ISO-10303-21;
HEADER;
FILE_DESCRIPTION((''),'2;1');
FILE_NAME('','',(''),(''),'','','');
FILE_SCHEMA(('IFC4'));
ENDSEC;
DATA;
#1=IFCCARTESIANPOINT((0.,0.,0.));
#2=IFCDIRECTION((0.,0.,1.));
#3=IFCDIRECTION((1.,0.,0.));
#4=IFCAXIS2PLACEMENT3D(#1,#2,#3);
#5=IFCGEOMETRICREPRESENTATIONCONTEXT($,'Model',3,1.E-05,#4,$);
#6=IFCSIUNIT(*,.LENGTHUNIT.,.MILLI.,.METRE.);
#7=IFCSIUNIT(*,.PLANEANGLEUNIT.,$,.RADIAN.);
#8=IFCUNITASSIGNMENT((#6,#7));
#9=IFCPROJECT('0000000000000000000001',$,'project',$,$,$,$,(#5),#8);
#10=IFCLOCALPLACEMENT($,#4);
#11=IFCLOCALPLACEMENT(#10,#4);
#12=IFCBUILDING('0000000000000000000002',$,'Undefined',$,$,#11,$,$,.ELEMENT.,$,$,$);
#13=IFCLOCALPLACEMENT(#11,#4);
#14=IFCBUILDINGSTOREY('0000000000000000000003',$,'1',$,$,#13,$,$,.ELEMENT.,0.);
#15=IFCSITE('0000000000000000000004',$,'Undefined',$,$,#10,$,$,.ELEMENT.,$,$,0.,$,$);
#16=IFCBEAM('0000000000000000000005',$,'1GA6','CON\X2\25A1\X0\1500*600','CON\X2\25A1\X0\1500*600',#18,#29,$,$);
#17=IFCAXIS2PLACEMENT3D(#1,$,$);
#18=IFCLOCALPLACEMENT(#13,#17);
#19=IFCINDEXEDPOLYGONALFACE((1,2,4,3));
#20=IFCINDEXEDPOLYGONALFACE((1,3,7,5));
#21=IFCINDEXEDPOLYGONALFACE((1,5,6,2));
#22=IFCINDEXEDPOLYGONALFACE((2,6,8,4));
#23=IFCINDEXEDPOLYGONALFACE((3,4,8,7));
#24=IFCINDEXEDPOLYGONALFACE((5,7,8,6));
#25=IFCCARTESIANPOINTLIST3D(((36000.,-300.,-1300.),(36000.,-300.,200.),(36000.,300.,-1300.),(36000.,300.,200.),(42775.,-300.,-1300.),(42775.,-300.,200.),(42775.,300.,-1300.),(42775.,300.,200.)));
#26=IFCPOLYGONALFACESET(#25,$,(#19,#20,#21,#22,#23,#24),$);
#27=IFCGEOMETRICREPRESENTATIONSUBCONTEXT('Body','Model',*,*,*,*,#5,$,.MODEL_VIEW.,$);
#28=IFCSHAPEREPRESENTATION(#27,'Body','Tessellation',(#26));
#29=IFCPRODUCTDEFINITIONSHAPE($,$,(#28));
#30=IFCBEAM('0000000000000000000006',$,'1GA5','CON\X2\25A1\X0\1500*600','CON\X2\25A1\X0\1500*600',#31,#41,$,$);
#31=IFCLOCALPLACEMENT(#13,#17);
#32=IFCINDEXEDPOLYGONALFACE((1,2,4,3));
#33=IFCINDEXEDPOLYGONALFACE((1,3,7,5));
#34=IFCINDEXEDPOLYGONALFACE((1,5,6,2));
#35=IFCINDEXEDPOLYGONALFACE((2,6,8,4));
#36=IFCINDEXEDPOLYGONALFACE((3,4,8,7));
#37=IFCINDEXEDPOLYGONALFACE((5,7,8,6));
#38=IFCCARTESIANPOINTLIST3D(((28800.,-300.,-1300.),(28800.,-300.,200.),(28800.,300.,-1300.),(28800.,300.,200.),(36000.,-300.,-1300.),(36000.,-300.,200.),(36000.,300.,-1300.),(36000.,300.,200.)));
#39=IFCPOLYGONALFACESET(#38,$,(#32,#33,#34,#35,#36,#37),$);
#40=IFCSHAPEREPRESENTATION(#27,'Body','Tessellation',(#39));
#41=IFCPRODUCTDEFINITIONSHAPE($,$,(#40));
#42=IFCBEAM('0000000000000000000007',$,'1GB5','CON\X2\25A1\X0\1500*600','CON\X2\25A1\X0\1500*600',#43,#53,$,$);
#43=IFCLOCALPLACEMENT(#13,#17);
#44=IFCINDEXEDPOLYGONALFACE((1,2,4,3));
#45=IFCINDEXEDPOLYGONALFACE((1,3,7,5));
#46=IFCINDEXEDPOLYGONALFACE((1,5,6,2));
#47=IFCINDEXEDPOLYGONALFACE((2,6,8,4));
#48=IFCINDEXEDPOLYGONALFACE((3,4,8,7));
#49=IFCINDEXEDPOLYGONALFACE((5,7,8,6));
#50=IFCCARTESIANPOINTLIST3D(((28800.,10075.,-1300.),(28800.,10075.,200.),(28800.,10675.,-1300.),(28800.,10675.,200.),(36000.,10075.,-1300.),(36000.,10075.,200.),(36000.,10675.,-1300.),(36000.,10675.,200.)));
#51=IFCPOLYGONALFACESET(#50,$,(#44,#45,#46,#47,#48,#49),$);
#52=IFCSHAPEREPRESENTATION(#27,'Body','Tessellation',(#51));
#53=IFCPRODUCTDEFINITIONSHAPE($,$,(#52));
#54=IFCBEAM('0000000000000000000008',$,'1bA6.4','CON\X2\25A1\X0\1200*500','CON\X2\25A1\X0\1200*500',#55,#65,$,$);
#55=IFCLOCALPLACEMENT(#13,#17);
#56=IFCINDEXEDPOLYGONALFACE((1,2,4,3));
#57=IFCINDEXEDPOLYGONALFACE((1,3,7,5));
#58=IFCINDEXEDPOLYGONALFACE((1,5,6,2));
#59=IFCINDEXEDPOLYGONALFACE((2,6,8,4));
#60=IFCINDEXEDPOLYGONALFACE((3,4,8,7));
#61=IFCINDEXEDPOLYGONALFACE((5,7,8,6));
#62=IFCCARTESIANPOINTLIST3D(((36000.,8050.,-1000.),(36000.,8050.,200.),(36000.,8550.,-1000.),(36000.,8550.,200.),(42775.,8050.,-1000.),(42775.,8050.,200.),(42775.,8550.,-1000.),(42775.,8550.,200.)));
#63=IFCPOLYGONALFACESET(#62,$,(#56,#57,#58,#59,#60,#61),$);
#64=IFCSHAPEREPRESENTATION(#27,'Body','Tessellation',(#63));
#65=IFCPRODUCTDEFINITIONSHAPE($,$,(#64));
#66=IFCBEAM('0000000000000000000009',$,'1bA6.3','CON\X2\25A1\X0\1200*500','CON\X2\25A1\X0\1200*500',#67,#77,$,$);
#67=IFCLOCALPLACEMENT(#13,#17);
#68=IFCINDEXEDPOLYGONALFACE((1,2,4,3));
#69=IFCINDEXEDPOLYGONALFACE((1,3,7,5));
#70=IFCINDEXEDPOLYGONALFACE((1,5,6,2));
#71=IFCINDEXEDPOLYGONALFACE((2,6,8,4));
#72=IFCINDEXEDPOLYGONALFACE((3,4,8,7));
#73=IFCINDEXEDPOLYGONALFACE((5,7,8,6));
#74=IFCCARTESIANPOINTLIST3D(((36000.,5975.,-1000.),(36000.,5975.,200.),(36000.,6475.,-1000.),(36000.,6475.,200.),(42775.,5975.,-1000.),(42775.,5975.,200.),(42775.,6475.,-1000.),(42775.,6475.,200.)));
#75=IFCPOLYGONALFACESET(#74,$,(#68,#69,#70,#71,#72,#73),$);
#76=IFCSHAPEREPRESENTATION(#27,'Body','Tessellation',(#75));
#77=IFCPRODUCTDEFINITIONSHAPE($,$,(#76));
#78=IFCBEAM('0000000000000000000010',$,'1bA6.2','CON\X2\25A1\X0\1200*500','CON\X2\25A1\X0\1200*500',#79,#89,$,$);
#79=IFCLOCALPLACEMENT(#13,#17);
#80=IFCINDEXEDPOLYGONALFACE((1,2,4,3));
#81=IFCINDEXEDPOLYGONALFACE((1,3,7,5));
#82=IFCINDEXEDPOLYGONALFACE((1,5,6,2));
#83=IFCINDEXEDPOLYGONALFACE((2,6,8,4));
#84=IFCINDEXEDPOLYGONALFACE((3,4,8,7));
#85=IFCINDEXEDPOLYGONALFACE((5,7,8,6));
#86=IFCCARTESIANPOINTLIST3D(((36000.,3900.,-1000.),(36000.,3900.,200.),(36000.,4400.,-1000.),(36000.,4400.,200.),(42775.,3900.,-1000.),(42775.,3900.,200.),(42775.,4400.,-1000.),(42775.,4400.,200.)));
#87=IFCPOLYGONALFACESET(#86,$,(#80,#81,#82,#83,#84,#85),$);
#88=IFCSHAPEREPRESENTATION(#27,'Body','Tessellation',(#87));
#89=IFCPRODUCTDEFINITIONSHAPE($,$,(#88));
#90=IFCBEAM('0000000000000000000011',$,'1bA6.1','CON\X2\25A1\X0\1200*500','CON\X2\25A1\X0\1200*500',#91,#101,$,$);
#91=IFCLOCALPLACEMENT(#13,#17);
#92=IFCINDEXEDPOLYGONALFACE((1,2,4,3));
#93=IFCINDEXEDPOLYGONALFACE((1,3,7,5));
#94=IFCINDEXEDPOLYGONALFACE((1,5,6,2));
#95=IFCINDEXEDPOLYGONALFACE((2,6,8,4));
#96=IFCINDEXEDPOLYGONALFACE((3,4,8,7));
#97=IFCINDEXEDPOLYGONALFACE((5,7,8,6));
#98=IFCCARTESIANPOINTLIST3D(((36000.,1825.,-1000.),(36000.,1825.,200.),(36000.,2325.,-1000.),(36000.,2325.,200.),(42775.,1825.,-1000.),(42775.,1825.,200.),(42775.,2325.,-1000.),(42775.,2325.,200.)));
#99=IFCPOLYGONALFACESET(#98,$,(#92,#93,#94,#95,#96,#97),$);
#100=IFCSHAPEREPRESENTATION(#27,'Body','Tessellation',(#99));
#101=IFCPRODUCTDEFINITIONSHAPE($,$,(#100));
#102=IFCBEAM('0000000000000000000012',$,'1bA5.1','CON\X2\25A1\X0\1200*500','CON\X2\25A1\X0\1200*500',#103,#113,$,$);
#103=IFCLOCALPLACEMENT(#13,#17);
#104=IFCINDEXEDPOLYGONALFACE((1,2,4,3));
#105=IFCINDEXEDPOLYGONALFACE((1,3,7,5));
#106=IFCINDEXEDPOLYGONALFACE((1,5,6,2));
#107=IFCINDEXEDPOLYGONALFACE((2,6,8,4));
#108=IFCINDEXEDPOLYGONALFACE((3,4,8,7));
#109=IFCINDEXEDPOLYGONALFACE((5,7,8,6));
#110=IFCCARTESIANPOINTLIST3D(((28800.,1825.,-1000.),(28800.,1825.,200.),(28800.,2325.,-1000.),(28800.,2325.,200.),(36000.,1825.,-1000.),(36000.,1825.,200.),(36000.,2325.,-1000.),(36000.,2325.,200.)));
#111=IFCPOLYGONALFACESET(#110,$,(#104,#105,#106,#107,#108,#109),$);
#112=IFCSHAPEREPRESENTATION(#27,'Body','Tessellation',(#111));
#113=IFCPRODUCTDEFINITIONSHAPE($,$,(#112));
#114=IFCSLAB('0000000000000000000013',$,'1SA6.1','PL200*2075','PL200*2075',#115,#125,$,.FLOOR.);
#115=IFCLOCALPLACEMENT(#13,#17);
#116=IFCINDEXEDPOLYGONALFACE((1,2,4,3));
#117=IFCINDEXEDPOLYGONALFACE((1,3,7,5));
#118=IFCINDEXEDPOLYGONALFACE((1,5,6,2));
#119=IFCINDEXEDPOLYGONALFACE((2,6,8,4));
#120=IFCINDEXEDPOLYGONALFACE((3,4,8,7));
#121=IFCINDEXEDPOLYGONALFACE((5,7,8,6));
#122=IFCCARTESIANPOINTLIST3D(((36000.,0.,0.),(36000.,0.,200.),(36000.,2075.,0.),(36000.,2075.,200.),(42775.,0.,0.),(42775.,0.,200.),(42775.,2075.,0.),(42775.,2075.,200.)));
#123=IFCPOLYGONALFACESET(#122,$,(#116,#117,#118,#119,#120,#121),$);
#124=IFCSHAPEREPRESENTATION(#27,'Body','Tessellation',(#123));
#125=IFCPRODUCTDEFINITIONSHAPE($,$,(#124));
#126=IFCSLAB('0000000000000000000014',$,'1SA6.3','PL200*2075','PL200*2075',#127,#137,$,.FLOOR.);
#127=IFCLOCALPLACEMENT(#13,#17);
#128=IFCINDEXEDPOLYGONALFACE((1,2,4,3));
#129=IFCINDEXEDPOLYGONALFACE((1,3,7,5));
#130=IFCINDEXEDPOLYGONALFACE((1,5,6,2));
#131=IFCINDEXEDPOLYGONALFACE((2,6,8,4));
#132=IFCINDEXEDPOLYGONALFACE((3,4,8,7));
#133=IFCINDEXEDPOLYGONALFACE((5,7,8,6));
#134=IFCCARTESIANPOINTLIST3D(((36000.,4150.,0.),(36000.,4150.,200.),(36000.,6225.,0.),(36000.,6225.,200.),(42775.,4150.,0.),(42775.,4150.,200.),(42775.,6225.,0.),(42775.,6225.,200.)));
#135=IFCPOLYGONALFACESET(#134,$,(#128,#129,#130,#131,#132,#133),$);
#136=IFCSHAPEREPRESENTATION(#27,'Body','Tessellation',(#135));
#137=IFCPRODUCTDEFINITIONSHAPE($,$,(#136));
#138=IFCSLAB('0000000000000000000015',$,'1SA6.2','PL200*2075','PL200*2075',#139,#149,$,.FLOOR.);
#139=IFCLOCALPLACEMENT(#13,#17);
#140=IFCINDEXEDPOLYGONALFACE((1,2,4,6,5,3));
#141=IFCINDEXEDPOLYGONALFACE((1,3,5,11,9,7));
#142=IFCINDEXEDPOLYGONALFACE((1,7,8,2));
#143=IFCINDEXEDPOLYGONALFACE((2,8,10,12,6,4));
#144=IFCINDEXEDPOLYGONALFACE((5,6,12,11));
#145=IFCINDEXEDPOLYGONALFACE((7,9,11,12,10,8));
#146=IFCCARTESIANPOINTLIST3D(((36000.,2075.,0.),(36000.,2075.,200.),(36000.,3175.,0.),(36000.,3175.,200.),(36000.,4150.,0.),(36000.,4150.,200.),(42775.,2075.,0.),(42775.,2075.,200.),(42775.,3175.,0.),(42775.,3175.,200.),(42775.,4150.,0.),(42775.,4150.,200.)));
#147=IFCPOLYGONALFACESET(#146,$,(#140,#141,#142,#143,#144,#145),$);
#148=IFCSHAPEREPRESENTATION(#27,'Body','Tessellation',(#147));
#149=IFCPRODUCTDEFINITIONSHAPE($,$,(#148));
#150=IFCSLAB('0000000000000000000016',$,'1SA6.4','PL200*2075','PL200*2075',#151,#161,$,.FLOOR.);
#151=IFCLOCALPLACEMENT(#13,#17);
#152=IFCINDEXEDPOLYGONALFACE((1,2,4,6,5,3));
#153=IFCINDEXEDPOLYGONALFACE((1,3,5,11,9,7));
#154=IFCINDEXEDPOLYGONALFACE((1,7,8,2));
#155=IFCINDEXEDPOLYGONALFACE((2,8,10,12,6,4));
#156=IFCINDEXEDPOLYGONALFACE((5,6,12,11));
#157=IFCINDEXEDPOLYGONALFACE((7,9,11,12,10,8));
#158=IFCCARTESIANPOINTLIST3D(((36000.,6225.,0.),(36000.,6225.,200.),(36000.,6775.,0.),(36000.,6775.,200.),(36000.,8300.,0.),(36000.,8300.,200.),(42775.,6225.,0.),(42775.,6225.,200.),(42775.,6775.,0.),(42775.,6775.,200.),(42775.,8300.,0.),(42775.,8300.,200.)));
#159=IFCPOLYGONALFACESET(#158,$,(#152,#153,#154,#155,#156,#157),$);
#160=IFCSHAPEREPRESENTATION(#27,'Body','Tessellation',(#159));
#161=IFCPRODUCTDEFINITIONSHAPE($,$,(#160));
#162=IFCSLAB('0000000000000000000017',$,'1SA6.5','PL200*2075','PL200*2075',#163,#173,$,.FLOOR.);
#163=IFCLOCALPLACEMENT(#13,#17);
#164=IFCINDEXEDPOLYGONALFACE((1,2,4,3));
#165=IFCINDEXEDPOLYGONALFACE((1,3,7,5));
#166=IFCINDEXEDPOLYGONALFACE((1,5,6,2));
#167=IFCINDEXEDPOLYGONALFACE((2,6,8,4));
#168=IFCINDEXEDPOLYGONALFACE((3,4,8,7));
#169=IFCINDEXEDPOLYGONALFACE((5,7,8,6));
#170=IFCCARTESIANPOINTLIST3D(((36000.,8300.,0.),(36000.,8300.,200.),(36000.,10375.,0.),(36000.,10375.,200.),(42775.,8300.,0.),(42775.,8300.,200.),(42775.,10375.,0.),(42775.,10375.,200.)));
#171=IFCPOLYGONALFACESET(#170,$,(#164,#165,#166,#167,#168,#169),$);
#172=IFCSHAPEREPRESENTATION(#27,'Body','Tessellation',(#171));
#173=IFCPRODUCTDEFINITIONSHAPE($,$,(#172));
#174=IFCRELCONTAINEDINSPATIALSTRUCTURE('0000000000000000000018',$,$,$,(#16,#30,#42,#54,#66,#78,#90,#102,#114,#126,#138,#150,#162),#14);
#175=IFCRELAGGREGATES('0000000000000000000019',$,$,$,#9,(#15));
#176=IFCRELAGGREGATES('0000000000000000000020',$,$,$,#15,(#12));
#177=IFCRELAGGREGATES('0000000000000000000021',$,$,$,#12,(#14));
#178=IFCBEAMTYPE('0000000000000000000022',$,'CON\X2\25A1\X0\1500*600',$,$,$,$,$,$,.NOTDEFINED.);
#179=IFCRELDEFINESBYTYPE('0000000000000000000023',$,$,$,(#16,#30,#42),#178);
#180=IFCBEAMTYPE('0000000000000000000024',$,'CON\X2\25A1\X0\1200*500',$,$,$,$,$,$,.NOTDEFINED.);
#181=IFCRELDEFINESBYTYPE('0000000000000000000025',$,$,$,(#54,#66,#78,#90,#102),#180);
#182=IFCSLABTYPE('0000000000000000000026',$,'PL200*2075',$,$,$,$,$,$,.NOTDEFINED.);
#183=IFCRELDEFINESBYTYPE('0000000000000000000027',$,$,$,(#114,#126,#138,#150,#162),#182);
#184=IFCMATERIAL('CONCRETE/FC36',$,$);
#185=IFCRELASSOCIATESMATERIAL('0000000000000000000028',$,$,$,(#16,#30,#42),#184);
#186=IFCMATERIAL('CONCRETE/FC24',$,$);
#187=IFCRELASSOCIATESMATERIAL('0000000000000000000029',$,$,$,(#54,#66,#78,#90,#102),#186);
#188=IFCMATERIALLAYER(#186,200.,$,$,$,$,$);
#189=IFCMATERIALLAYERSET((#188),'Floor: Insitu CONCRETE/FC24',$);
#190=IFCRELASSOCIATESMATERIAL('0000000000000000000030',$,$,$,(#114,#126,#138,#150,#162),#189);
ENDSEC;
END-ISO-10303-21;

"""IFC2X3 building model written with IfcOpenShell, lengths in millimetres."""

from ifc_helpers import new_model, si_unit, frame, origin_with_axes, origin_2d_with_axis, place, context, subcontext, project, spatial, polyline, rectangle, outline, extrude, material, layer, layer_set, layer_usage, type_object, element, save


model = new_model("IFC2X3")

# Units and contexts
model_context = context("Model", 3, precision=1e-05, world=origin_with_axes())
body_context = subcontext(model_context, "Body", "Model", "MODEL_VIEW")
ifc_project = project(units=[si_unit("LENGTHUNIT", "METRE", prefix="MILLI"), si_unit("PLANEANGLEUNIT", "RADIAN")], contexts=[model_context])

# Site, building, storey
site_placement = place(None, origin_with_axes())
site = spatial("IfcSite", under=ifc_project, at=site_placement, Name="Undefined", CompositionType="ELEMENT", RefElevation=0.0)
building_placement = place(site_placement, origin_with_axes())
building = spatial("IfcBuilding", under=site, at=building_placement, Name="Undefined", CompositionType="ELEMENT")
storey_placement = place(building_placement, origin_with_axes())
storey = spatial("IfcBuildingStorey", under=building, at=storey_placement, Name="1", CompositionType="ELEMENT", Elevation=0.0)

# Shared definitions
ifc_material_1 = material(Name="CONCRETE/FC24")

# Beams
ifc_material_2 = material(Name="CONCRETE/FC36")
beam_type_1 = type_object("IfcBeamType", Name="CON□1500*600", PredefinedType="NOTDEFINED")
beam_1_placement = place(storey_placement, frame((36000.0, 0.0, -550.0), z_axis=(0.0, 0.0, 1.0), x_axis=(1.0, 0.0, 0.0)))
element("IfcBeam", 1, at=beam_1_placement, inside=storey, type_object=beam_type_1, material=ifc_material_2, Name="1GA6", Description="CON□1500*600", ObjectType="CON□1500*600", context=body_context, shape_type="SweptSolid", body=[
    extrude(rectangle(XDim=600.0, YDim=1500.0, at=origin_2d_with_axis()), frame((6775.0, 0.0, 0.0), z_axis=(-1.0, 0.0, 0.0), x_axis=(0.0, -1.0, 0.0)), (0.0, 0.0, 1.0), 6775.0),
])
for number, where, z_axis, x_axis, name in (
    (2, (28800.0, 0.0, -550.0), (0.0, 0.0, 1.0), (1.0, 0.0, 0.0), "1GA5"),
    (3, (28800.0, 10375.0, -550.0), (0.0, 0.0, 1.0), (1.0, 0.0, 0.0), "1GB5"),
):
    element("IfcBeam", number, at=place(storey_placement, frame(where, z_axis=z_axis, x_axis=x_axis)), inside=storey, type_object=beam_type_1, material=ifc_material_2, Name=name, Description="CON□1500*600", ObjectType="CON□1500*600", context=body_context, shape_type="SweptSolid", body=[
        extrude(rectangle(XDim=600.0, YDim=1500.0, at=origin_2d_with_axis()), frame((7200.0, 0.0, 0.0), z_axis=(-1.0, 0.0, 0.0), x_axis=(0.0, -1.0, 0.0)), (0.0, 0.0, 1.0), 7200.0),
    ])
beam_type_2 = type_object("IfcBeamType", Name="CON□1200*500", PredefinedType="NOTDEFINED")
for number, where, z_axis, x_axis, name in (
    (4, (36000.0, 8300.0, -400.0), (0.0, 0.0, 1.0), (1.0, 0.0, 0.0), "1bA6.4"),
    (5, (36000.0, 6225.0, -400.0), (0.0, 0.0, 1.0), (1.0, 0.0, 0.0), "1bA6.3"),
    (6, (36000.0, 4150.0, -400.0), (0.0, 0.0, 1.0), (1.0, 0.0, 0.0), "1bA6.2"),
    (7, (36000.0, 2075.0, -400.0), (0.0, 0.0, 1.0), (1.0, 0.0, 0.0), "1bA6.1"),
):
    element("IfcBeam", number, at=place(storey_placement, frame(where, z_axis=z_axis, x_axis=x_axis)), inside=storey, type_object=beam_type_2, material=ifc_material_1, Name=name, Description="CON□1200*500", ObjectType="CON□1200*500", context=body_context, shape_type="SweptSolid", body=[
        extrude(rectangle(XDim=500.0, YDim=1200.0, at=origin_2d_with_axis()), frame((6775.0, 0.0, 0.0), z_axis=(-1.0, 0.0, 0.0), x_axis=(0.0, -1.0, 0.0)), (0.0, 0.0, 1.0), 6775.0),
    ])
beam_2_placement = place(storey_placement, frame((28800.0, 2075.0, -400.0), z_axis=(0.0, 0.0, 1.0), x_axis=(1.0, 0.0, 0.0)))
element("IfcBeam", 8, at=beam_2_placement, inside=storey, type_object=beam_type_2, material=ifc_material_1, Name="1bA5.1", Description="CON□1200*500", ObjectType="CON□1200*500", context=body_context, shape_type="SweptSolid", body=[
    extrude(rectangle(XDim=500.0, YDim=1200.0, at=origin_2d_with_axis()), frame((7200.0, 0.0, 0.0), z_axis=(-1.0, 0.0, 0.0), x_axis=(0.0, -1.0, 0.0)), (0.0, 0.0, 1.0), 7200.0),
])

# Slabs
ifc_layer = layer(ifc_material_1, 200.0)
ifc_layer_set = layer_set([ifc_layer], Name="Floor: Insitu CONCRETE/FC24")
ifc_layer_usage_1 = layer_usage(ifc_layer_set, "AXIS3", "POSITIVE", -100.0)
slab_type = type_object("IfcSlabType", Name="PL200*2075", PredefinedType="NOTDEFINED")
slab_1_placement = place(storey_placement, frame((36000.0, 0.0, 100.0), z_axis=(0.0, 0.0, 1.0), x_axis=(1.0, 0.0, 0.0)))
element("IfcSlab", 9, at=slab_1_placement, inside=storey, type_object=slab_type, material=ifc_layer_usage_1, Name="1SA6.1", Description="PL200*2075", ObjectType="PL200*2075", PredefinedType="FLOOR", context=body_context, shape_type="SweptSolid", body=[
    extrude(outline(polyline([(0.0, 0.0), (6775.0, 0.0), (6775.0, 2075.0), (0.0, 2075.0), (0.0, 0.0)])), frame((0.0, 0.0, -100.0), z_axis=(0.0, 0.0, 1.0), x_axis=(1.0, 0.0, 0.0)), (0.0, 0.0, 1.0), 200.0),
])
ifc_layer_usage_2 = layer_usage(ifc_layer_set, "AXIS3", "POSITIVE", -100.0)
slab_2_placement = place(storey_placement, frame((36000.0, 4150.0, 100.0), z_axis=(0.0, 0.0, 1.0), x_axis=(1.0, 0.0, 0.0)))
element("IfcSlab", 10, at=slab_2_placement, inside=storey, type_object=slab_type, material=ifc_layer_usage_2, Name="1SA6.3", Description="PL200*2075", ObjectType="PL200*2075", PredefinedType="FLOOR", context=body_context, shape_type="SweptSolid", body=[
    extrude(outline(polyline([(0.0, 0.0), (6775.0, 0.0), (6775.0, 2075.0), (0.0, 2075.0), (0.0, 0.0)])), frame((0.0, 0.0, -100.0), z_axis=(0.0, 0.0, 1.0), x_axis=(1.0, 0.0, 0.0)), (0.0, 0.0, 1.0), 200.0),
])
ifc_layer_usage_3 = layer_usage(ifc_layer_set, "AXIS3", "POSITIVE", -100.0)
slab_3_placement = place(storey_placement, frame((36000.0, 2075.0, 100.0), z_axis=(0.0, 0.0, 1.0), x_axis=(1.0, 0.0, 0.0)))
element("IfcSlab", 11, at=slab_3_placement, inside=storey, type_object=slab_type, material=ifc_layer_usage_3, Name="1SA6.2", Description="PL200*2075", ObjectType="PL200*2075", PredefinedType="FLOOR", context=body_context, shape_type="SweptSolid", body=[
    extrude(outline(polyline([(0.0, 0.0), (6775.0, 0.0), (6775.0, 1100.0), (6775.0, 2075.0), (0.0, 2075.0), (0.0, 1100.0), (0.0, 0.0)])), frame((0.0, 0.0, -100.0), z_axis=(0.0, 0.0, 1.0), x_axis=(1.0, 0.0, 0.0)), (0.0, 0.0, 1.0), 200.0),
])
ifc_layer_usage_4 = layer_usage(ifc_layer_set, "AXIS3", "POSITIVE", -100.0)
slab_4_placement = place(storey_placement, frame((36000.0, 6225.0, 100.0), z_axis=(0.0, 0.0, 1.0), x_axis=(1.0, 0.0, 0.0)))
element("IfcSlab", 12, at=slab_4_placement, inside=storey, type_object=slab_type, material=ifc_layer_usage_4, Name="1SA6.4", Description="PL200*2075", ObjectType="PL200*2075", PredefinedType="FLOOR", context=body_context, shape_type="SweptSolid", body=[
    extrude(outline(polyline([(0.0, 0.0), (6775.0, 0.0), (6775.0, 550.0), (6775.0, 2075.0), (0.0, 2075.0), (0.0, 550.0), (0.0, 0.0)])), frame((0.0, 0.0, -100.0), z_axis=(0.0, 0.0, 1.0), x_axis=(1.0, 0.0, 0.0)), (0.0, 0.0, 1.0), 200.0),
])
ifc_layer_usage_5 = layer_usage(ifc_layer_set, "AXIS3", "POSITIVE", -100.0)
slab_5_placement = place(storey_placement, frame((36000.0, 8300.0, 100.0), z_axis=(0.0, 0.0, 1.0), x_axis=(1.0, 0.0, 0.0)))
element("IfcSlab", 13, at=slab_5_placement, inside=storey, type_object=slab_type, material=ifc_layer_usage_5, Name="1SA6.5", Description="PL200*2075", ObjectType="PL200*2075", PredefinedType="FLOOR", context=body_context, shape_type="SweptSolid", body=[
    extrude(outline(polyline([(0.0, 0.0), (6775.0, 0.0), (6775.0, 2075.0), (0.0, 2075.0), (0.0, 0.0)])), frame((0.0, 0.0, -100.0), z_axis=(0.0, 0.0, 1.0), x_axis=(1.0, 0.0, 0.0)), (0.0, 0.0, 1.0), 200.0),
])

save(model, "model.ifc")
